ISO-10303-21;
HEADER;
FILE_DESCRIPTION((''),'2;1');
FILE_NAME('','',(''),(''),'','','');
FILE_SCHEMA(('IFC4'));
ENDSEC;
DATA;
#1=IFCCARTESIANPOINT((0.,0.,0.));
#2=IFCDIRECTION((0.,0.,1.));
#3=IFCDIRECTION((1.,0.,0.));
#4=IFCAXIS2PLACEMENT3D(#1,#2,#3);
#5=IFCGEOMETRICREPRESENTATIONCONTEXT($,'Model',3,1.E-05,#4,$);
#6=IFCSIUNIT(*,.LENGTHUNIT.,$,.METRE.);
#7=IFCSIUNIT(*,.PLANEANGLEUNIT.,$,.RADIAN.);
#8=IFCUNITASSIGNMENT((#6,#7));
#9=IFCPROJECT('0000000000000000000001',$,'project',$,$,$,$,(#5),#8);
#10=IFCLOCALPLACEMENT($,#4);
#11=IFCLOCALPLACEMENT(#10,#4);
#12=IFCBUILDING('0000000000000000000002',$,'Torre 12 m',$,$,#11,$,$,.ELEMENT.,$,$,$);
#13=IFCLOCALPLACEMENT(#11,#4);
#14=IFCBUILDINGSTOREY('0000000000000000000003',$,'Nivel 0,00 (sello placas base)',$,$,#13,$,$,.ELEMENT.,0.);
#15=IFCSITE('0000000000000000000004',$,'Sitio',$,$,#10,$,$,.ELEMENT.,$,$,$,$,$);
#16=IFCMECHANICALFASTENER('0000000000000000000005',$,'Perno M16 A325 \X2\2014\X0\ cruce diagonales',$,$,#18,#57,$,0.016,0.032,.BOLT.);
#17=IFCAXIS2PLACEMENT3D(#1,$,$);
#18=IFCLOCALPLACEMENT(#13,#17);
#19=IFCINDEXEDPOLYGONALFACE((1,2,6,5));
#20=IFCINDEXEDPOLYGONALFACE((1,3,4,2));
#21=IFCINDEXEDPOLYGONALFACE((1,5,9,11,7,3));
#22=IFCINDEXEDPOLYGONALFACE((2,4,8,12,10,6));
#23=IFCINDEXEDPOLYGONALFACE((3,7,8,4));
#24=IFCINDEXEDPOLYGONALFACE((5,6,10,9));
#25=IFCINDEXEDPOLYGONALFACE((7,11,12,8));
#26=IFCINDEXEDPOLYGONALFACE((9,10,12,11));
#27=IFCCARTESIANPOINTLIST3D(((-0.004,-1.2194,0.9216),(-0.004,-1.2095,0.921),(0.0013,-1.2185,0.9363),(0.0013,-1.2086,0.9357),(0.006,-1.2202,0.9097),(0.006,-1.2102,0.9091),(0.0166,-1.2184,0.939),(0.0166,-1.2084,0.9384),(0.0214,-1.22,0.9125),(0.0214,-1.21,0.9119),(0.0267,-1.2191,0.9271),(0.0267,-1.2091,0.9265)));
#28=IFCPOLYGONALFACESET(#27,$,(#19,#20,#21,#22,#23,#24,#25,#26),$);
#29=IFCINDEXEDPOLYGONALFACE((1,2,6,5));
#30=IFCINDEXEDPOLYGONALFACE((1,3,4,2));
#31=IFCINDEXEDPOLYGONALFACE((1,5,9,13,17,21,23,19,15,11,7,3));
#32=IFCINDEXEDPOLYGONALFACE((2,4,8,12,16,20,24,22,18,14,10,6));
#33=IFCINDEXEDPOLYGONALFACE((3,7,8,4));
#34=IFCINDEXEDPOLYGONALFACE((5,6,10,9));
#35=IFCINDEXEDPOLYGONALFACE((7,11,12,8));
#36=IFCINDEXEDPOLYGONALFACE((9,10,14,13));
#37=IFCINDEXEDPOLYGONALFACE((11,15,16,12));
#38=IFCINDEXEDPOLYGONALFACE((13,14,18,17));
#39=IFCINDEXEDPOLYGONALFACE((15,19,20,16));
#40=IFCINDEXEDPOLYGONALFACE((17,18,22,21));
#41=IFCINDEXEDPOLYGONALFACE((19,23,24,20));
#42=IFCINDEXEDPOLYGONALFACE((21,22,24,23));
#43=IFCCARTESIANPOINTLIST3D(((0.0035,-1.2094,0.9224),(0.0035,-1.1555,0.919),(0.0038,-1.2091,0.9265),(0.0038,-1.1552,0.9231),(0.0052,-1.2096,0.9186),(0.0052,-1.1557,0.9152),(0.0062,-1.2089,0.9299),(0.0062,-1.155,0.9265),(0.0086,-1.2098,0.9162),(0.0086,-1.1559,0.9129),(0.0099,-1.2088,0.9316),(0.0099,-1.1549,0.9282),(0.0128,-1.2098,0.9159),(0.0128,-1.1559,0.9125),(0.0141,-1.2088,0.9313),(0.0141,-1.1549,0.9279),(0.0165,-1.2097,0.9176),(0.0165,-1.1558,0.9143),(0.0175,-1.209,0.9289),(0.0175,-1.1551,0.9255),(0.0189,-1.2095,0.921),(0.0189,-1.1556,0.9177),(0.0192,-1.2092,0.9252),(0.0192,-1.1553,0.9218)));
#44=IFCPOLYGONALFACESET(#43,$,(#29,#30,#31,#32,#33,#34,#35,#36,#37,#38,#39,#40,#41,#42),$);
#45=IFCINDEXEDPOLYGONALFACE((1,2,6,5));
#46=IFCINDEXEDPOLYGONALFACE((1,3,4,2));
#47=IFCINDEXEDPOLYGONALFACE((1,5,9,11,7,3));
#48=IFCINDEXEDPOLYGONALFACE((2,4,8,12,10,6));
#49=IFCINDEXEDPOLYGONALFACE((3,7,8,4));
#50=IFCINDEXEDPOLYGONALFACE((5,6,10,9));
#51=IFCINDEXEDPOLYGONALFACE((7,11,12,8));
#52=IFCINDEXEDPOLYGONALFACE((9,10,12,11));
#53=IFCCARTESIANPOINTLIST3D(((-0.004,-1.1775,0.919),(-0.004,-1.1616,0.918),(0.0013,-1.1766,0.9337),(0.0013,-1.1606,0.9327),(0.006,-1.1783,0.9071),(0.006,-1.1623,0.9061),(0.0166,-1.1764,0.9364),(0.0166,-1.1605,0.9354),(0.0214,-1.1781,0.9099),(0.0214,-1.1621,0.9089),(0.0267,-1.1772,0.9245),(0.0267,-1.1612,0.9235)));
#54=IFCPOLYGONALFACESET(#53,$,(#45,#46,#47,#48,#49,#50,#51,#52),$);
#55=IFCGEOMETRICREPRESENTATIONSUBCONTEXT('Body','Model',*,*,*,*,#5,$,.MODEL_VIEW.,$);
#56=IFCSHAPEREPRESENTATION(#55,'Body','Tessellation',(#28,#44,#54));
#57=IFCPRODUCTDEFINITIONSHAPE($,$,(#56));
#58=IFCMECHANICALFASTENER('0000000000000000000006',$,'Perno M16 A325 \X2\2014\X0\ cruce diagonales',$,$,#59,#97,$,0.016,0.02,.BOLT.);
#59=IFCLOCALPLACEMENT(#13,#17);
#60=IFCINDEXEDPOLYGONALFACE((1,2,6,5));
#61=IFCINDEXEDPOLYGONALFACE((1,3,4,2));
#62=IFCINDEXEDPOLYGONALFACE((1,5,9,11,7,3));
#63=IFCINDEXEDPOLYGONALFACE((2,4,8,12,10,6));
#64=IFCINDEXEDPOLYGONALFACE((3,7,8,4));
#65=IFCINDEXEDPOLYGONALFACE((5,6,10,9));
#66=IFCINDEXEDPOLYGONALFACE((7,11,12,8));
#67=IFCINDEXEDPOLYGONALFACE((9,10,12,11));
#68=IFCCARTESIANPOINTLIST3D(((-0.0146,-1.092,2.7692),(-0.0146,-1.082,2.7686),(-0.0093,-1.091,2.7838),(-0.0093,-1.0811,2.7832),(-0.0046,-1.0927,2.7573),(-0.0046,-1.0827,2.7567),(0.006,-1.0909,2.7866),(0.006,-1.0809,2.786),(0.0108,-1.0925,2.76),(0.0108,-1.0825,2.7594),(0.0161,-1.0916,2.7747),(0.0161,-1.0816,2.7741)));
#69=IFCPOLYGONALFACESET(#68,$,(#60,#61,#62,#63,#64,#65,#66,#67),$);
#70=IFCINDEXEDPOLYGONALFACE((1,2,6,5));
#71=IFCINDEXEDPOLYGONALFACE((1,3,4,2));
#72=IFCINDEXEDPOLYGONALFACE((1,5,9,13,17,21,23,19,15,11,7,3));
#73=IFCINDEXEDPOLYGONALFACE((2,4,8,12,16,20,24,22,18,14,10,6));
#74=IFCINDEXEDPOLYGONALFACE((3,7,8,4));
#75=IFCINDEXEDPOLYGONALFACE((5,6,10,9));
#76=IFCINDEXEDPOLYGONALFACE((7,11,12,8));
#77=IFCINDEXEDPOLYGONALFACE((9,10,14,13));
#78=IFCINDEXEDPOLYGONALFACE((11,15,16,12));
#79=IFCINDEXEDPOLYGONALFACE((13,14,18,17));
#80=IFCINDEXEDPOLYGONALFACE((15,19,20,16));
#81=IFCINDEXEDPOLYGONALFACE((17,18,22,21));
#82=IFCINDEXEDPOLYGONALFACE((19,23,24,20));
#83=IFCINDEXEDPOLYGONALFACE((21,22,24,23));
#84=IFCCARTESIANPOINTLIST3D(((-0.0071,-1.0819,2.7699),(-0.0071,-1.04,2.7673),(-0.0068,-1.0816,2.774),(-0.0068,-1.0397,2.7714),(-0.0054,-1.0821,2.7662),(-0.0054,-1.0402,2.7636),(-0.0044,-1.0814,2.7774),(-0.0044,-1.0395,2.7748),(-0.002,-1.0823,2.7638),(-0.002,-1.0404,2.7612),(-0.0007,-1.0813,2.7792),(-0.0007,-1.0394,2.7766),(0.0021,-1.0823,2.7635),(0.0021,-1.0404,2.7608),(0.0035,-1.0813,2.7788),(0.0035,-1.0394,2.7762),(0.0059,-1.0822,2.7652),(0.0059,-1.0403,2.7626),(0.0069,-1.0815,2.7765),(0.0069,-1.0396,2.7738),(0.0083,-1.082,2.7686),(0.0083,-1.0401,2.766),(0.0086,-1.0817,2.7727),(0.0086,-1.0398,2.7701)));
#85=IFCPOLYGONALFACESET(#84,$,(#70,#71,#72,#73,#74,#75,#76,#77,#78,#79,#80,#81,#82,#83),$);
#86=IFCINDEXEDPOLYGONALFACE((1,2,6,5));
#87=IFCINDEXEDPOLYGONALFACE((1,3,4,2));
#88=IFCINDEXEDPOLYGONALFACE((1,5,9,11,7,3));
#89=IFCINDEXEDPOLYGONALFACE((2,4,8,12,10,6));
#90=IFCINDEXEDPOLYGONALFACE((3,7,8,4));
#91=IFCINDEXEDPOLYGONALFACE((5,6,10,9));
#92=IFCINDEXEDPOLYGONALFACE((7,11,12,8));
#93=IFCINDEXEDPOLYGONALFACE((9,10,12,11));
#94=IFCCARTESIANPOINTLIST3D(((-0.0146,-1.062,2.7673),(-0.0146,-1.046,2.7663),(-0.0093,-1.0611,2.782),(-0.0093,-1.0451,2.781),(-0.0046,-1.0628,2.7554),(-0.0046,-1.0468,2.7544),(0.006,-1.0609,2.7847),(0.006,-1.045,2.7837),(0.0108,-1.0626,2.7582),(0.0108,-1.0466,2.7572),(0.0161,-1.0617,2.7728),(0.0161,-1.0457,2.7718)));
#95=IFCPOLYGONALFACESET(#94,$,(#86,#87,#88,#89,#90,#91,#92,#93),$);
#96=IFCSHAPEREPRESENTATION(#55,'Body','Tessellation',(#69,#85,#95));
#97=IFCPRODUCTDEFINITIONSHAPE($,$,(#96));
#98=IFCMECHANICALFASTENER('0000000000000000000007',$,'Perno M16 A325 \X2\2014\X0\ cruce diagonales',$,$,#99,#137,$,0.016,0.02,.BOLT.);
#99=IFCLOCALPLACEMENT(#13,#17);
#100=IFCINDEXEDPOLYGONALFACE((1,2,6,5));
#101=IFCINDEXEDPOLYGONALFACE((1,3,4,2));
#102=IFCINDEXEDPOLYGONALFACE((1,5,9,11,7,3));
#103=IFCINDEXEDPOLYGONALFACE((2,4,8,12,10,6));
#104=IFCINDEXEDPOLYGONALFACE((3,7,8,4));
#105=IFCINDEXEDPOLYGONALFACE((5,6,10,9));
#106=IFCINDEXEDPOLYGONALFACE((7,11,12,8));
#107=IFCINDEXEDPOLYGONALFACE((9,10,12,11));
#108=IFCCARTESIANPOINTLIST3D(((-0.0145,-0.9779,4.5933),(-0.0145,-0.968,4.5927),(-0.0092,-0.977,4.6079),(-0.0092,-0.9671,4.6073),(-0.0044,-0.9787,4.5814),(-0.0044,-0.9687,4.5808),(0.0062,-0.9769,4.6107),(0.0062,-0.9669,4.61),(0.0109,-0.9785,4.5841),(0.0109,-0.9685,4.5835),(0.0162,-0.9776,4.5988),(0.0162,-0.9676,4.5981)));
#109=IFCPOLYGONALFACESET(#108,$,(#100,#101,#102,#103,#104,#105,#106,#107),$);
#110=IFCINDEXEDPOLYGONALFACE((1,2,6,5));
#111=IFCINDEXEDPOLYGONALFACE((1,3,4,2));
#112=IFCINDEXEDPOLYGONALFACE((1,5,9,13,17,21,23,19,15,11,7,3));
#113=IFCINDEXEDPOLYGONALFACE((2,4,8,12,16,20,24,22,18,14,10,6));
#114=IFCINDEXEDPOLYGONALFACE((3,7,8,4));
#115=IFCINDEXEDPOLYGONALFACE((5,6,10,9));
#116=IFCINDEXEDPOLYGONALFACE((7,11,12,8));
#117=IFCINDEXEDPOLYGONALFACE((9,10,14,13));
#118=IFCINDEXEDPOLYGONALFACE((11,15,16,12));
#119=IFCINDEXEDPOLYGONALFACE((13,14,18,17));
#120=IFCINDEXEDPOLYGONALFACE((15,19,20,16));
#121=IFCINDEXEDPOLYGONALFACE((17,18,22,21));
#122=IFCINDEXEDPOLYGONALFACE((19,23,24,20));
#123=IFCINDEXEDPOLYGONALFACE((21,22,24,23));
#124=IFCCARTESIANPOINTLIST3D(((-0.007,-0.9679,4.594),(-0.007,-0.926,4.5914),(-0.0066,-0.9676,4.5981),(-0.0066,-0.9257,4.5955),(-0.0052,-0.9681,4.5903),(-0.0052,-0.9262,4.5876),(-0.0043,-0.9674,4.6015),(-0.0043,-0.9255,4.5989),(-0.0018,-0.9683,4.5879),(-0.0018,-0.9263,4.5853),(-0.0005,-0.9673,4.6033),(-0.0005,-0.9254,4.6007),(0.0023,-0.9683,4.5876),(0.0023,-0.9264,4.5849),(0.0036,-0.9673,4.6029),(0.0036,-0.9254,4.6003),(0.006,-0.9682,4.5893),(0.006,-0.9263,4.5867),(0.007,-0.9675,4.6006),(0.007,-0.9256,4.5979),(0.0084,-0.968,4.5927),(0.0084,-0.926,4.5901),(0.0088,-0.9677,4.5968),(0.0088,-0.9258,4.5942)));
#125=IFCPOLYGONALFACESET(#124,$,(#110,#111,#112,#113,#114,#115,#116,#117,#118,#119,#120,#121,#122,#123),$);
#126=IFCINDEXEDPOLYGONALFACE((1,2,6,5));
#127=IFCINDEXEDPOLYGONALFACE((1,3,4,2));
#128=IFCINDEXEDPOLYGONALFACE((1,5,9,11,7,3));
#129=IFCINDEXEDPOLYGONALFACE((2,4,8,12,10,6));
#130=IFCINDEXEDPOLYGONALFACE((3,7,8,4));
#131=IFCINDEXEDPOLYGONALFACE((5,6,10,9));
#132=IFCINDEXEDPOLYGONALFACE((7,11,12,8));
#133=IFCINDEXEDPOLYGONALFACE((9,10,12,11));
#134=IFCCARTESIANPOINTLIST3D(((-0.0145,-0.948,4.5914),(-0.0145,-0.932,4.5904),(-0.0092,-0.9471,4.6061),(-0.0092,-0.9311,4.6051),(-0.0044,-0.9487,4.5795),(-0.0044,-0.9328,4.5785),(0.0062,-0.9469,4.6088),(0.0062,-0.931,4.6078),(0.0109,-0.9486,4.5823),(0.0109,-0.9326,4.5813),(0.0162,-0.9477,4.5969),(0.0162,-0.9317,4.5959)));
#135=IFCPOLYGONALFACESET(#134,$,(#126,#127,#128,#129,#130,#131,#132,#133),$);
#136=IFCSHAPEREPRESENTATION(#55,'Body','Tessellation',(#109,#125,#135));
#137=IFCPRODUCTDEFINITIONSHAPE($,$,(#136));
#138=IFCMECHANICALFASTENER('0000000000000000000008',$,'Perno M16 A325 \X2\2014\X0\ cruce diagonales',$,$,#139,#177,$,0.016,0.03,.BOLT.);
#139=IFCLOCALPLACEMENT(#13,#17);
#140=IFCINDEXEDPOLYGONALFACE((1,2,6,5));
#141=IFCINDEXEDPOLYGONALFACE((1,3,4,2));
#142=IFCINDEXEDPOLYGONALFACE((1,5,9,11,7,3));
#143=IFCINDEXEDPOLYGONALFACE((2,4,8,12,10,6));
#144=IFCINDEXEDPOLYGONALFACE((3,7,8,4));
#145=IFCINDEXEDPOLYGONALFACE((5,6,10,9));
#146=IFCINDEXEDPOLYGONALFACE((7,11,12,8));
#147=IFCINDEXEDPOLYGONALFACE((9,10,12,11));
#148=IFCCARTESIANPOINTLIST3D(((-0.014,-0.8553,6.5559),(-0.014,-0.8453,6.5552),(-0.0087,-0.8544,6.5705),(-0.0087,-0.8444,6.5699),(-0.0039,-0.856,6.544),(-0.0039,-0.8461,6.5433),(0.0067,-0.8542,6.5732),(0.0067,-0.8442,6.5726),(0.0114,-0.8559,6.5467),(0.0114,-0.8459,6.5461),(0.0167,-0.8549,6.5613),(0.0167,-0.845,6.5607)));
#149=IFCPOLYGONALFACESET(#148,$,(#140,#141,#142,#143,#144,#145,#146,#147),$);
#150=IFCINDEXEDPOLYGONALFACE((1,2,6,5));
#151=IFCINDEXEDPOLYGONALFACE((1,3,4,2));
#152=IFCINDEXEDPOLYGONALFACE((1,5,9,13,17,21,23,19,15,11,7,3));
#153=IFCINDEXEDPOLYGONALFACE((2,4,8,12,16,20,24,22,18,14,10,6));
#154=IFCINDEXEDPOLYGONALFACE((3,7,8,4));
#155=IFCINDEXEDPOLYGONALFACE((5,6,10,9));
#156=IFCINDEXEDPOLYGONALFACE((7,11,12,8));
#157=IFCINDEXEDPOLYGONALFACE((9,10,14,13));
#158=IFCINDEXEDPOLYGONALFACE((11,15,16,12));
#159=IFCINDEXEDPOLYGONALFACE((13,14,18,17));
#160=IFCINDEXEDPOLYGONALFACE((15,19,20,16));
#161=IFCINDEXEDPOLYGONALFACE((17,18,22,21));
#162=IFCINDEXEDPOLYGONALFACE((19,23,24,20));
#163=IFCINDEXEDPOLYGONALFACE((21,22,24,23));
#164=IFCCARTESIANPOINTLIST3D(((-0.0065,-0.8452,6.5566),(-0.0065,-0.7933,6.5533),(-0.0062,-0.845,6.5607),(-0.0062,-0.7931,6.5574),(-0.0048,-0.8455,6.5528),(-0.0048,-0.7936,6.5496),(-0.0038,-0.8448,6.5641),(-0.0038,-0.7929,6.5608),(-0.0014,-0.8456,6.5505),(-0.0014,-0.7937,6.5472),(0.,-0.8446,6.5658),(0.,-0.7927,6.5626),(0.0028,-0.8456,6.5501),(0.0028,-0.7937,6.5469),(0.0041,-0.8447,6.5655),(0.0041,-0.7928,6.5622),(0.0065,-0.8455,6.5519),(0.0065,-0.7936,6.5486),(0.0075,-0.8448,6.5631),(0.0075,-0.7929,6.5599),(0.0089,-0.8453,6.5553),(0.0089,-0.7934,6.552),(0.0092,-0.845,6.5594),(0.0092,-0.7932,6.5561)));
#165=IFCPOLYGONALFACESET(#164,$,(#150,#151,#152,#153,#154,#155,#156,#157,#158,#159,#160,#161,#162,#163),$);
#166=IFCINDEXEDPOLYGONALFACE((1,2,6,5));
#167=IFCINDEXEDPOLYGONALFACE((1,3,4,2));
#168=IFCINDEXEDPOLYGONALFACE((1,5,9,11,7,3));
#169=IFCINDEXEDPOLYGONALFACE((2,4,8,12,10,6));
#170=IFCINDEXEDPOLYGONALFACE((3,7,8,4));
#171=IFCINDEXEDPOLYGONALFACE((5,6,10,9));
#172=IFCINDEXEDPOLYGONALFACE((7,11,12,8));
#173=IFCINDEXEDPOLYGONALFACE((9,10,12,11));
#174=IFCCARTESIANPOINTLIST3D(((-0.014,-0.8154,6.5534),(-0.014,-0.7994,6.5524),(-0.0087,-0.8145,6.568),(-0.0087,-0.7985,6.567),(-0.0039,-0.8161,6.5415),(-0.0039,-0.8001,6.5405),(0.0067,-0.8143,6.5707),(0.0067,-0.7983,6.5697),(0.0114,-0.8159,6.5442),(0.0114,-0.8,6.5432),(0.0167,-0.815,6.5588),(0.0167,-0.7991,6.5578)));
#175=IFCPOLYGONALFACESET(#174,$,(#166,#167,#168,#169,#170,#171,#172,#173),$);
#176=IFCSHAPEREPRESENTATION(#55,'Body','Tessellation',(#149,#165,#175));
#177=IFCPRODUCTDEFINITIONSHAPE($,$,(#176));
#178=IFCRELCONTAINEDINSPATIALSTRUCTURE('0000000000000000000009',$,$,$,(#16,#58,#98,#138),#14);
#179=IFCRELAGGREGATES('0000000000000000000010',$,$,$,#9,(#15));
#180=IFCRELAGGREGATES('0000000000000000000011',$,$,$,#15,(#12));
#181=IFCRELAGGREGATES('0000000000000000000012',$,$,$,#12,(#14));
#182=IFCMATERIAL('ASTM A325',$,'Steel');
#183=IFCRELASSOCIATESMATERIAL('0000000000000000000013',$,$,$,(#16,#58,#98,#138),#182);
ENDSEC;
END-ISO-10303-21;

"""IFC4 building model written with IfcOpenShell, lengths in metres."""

from ifc_helpers import new_model, si_unit, frame, origin_with_axes, place, context, subcontext, project, spatial, polyline, outline, extrude, material, element, save


model = new_model("IFC4")

# Units and contexts
model_context = context("Model", 3, precision=1e-05, world=origin_with_axes())
body_context = subcontext(model_context, "Body", "Model", "MODEL_VIEW")
ifc_project = project(units=[si_unit("LENGTHUNIT", "METRE"), si_unit("PLANEANGLEUNIT", "RADIAN")], contexts=[model_context])

# Site, building, storey
site_placement = place(None, origin_with_axes())
site = spatial("IfcSite", under=ifc_project, at=site_placement, Name="Sitio", CompositionType="ELEMENT")
building_placement = place(site_placement, origin_with_axes())
building = spatial("IfcBuilding", under=site, at=building_placement, Name="Torre 12 m", CompositionType="ELEMENT")
storey_placement = place(building_placement, origin_with_axes())
storey = spatial("IfcBuildingStorey", under=building, at=storey_placement, Name="Nivel 0,00 (sello placas base)", CompositionType="ELEMENT", Elevation=0.0)

# Shared definitions
placement = place(storey_placement, origin_with_axes())

# Mechanical fasteners
ifc_material_1 = material(Name="ASTM A325", Category="Steel")
element("IfcMechanicalFastener", 1, at=placement, inside=storey, material=ifc_material_1, Name="Perno M16 A325 — cruce diagonales", NominalDiameter=0.016, NominalLength=0.032, PredefinedType="BOLT", context=body_context, shape_type="SweptSolid", body=[
    extrude(outline(polyline([(0.0135, 0.0078), (0.0, 0.0156), (-0.0135, 0.0078), (-0.0135, -0.0078), (0.0, -0.0156), (0.0135, -0.0078), (0.0135, 0.0078)])), frame((0.0113, -1.2193, 0.9244), z_axis=(0.0, 0.998053, -0.062378), x_axis=(0.940405, -0.021212, -0.339394)), (0.0, 0.0, 1.0), 0.01),
    extrude(outline(polyline([(0.008, 0.0), (0.0069, 0.004), (0.004, 0.0069), (0.0, 0.008), (-0.004, 0.0069), (-0.0069, 0.004), (-0.008, 0.0), (-0.0069, -0.004), (-0.004, -0.0069), (0.0, -0.008), (0.004, -0.0069), (0.0069, -0.004), (0.008, 0.0)])), frame((0.0113, -1.2093, 0.9238), z_axis=(0.0, 0.998053, -0.062378), x_axis=(0.940405, -0.021212, -0.339394)), (0.0, 0.0, 1.0), 0.054),
    extrude(outline(polyline([(0.0135, 0.0078), (0.0, 0.0156), (-0.0135, 0.0078), (-0.0135, -0.0078), (0.0, -0.0156), (0.0135, -0.0078), (0.0135, 0.0078)])), frame((0.0113, -1.1774, 0.9218), z_axis=(0.0, 0.998053, -0.062378), x_axis=(0.940405, -0.021212, -0.339394)), (0.0, 0.0, 1.0), 0.016),
])
element("IfcMechanicalFastener", 2, at=placement, inside=storey, material=ifc_material_1, Name="Perno M16 A325 — cruce diagonales", NominalDiameter=0.016, NominalLength=0.02, PredefinedType="BOLT", context=body_context, shape_type="SweptSolid", body=[
    extrude(outline(polyline([(0.0135, 0.0078), (0.0, 0.0156), (-0.0135, 0.0078), (-0.0135, -0.0078), (0.0, -0.0156), (0.0135, -0.0078), (0.0135, 0.0078)])), frame((0.0007, -1.0918, 2.7719), z_axis=(0.0, 0.998053, -0.062378), x_axis=(0.940405, -0.021212, -0.339394)), (0.0, 0.0, 1.0), 0.01),
    extrude(outline(polyline([(0.008, 0.0), (0.0069, 0.004), (0.004, 0.0069), (0.0, 0.008), (-0.004, 0.0069), (-0.0069, 0.004), (-0.008, 0.0), (-0.0069, -0.004), (-0.004, -0.0069), (0.0, -0.008), (0.004, -0.0069), (0.0069, -0.004), (0.008, 0.0)])), frame((0.0007, -1.0818, 2.7713), z_axis=(0.0, 0.998053, -0.062378), x_axis=(0.940405, -0.021212, -0.339394)), (0.0, 0.0, 1.0), 0.042),
    extrude(outline(polyline([(0.0135, 0.0078), (0.0, 0.0156), (-0.0135, 0.0078), (-0.0135, -0.0078), (0.0, -0.0156), (0.0135, -0.0078), (0.0135, 0.0078)])), frame((0.0007, -1.0618, 2.7701), z_axis=(0.0, 0.998053, -0.062378), x_axis=(0.940405, -0.021212, -0.339394)), (0.0, 0.0, 1.0), 0.016),
])
element("IfcMechanicalFastener", 3, at=placement, inside=storey, material=ifc_material_1, Name="Perno M16 A325 — cruce diagonales", NominalDiameter=0.016, NominalLength=0.02, PredefinedType="BOLT", context=body_context, shape_type="SweptSolid", body=[
    extrude(outline(polyline([(0.0135, 0.0078), (0.0, 0.0156), (-0.0135, 0.0078), (-0.0135, -0.0078), (0.0, -0.0156), (0.0135, -0.0078), (0.0135, 0.0078)])), frame((0.0009, -0.9778, 4.596), z_axis=(0.0, 0.998053, -0.062378), x_axis=(0.940405, -0.021212, -0.339394)), (0.0, 0.0, 1.0), 0.01),
    extrude(outline(polyline([(0.008, 0.0), (0.0069, 0.004), (0.004, 0.0069), (0.0, 0.008), (-0.004, 0.0069), (-0.0069, 0.004), (-0.008, 0.0), (-0.0069, -0.004), (-0.004, -0.0069), (0.0, -0.008), (0.004, -0.0069), (0.0069, -0.004), (0.008, 0.0)])), frame((0.0009, -0.9678, 4.5954), z_axis=(0.0, 0.998053, -0.062378), x_axis=(0.940405, -0.021212, -0.339394)), (0.0, 0.0, 1.0), 0.042),
    extrude(outline(polyline([(0.0135, 0.0078), (0.0, 0.0156), (-0.0135, 0.0078), (-0.0135, -0.0078), (0.0, -0.0156), (0.0135, -0.0078), (0.0135, 0.0078)])), frame((0.0009, -0.9478, 4.5942), z_axis=(0.0, 0.998053, -0.062378), x_axis=(0.940405, -0.021212, -0.339394)), (0.0, 0.0, 1.0), 0.016),
])
element("IfcMechanicalFastener", 4, at=placement, inside=storey, material=ifc_material_1, Name="Perno M16 A325 — cruce diagonales", NominalDiameter=0.016, NominalLength=0.03, PredefinedType="BOLT", context=body_context, shape_type="SweptSolid", body=[
    extrude(outline(polyline([(0.0135, 0.0078), (0.0, 0.0156), (-0.0135, 0.0078), (-0.0135, -0.0078), (0.0, -0.0156), (0.0135, -0.0078), (0.0135, 0.0078)])), frame((0.0014, -0.8551, 6.5586), z_axis=(0.0, 0.998053, -0.062378), x_axis=(0.940405, -0.021212, -0.339394)), (0.0, 0.0, 1.0), 0.01),
    extrude(outline(polyline([(0.008, 0.0), (0.0069, 0.004), (0.004, 0.0069), (0.0, 0.008), (-0.004, 0.0069), (-0.0069, 0.004), (-0.008, 0.0), (-0.0069, -0.004), (-0.004, -0.0069), (0.0, -0.008), (0.004, -0.0069), (0.0069, -0.004), (0.008, 0.0)])), frame((0.0014, -0.8451, 6.558), z_axis=(0.0, 0.998053, -0.062378), x_axis=(0.940405, -0.021212, -0.339394)), (0.0, 0.0, 1.0), 0.052),
    extrude(outline(polyline([(0.0135, 0.0078), (0.0, 0.0156), (-0.0135, 0.0078), (-0.0135, -0.0078), (0.0, -0.0156), (0.0135, -0.0078), (0.0135, 0.0078)])), frame((0.0014, -0.8152, 6.5561), z_axis=(0.0, 0.998053, -0.062378), x_axis=(0.940405, -0.021212, -0.339394)), (0.0, 0.0, 1.0), 0.016),
])

save(model, "model.ifc")
